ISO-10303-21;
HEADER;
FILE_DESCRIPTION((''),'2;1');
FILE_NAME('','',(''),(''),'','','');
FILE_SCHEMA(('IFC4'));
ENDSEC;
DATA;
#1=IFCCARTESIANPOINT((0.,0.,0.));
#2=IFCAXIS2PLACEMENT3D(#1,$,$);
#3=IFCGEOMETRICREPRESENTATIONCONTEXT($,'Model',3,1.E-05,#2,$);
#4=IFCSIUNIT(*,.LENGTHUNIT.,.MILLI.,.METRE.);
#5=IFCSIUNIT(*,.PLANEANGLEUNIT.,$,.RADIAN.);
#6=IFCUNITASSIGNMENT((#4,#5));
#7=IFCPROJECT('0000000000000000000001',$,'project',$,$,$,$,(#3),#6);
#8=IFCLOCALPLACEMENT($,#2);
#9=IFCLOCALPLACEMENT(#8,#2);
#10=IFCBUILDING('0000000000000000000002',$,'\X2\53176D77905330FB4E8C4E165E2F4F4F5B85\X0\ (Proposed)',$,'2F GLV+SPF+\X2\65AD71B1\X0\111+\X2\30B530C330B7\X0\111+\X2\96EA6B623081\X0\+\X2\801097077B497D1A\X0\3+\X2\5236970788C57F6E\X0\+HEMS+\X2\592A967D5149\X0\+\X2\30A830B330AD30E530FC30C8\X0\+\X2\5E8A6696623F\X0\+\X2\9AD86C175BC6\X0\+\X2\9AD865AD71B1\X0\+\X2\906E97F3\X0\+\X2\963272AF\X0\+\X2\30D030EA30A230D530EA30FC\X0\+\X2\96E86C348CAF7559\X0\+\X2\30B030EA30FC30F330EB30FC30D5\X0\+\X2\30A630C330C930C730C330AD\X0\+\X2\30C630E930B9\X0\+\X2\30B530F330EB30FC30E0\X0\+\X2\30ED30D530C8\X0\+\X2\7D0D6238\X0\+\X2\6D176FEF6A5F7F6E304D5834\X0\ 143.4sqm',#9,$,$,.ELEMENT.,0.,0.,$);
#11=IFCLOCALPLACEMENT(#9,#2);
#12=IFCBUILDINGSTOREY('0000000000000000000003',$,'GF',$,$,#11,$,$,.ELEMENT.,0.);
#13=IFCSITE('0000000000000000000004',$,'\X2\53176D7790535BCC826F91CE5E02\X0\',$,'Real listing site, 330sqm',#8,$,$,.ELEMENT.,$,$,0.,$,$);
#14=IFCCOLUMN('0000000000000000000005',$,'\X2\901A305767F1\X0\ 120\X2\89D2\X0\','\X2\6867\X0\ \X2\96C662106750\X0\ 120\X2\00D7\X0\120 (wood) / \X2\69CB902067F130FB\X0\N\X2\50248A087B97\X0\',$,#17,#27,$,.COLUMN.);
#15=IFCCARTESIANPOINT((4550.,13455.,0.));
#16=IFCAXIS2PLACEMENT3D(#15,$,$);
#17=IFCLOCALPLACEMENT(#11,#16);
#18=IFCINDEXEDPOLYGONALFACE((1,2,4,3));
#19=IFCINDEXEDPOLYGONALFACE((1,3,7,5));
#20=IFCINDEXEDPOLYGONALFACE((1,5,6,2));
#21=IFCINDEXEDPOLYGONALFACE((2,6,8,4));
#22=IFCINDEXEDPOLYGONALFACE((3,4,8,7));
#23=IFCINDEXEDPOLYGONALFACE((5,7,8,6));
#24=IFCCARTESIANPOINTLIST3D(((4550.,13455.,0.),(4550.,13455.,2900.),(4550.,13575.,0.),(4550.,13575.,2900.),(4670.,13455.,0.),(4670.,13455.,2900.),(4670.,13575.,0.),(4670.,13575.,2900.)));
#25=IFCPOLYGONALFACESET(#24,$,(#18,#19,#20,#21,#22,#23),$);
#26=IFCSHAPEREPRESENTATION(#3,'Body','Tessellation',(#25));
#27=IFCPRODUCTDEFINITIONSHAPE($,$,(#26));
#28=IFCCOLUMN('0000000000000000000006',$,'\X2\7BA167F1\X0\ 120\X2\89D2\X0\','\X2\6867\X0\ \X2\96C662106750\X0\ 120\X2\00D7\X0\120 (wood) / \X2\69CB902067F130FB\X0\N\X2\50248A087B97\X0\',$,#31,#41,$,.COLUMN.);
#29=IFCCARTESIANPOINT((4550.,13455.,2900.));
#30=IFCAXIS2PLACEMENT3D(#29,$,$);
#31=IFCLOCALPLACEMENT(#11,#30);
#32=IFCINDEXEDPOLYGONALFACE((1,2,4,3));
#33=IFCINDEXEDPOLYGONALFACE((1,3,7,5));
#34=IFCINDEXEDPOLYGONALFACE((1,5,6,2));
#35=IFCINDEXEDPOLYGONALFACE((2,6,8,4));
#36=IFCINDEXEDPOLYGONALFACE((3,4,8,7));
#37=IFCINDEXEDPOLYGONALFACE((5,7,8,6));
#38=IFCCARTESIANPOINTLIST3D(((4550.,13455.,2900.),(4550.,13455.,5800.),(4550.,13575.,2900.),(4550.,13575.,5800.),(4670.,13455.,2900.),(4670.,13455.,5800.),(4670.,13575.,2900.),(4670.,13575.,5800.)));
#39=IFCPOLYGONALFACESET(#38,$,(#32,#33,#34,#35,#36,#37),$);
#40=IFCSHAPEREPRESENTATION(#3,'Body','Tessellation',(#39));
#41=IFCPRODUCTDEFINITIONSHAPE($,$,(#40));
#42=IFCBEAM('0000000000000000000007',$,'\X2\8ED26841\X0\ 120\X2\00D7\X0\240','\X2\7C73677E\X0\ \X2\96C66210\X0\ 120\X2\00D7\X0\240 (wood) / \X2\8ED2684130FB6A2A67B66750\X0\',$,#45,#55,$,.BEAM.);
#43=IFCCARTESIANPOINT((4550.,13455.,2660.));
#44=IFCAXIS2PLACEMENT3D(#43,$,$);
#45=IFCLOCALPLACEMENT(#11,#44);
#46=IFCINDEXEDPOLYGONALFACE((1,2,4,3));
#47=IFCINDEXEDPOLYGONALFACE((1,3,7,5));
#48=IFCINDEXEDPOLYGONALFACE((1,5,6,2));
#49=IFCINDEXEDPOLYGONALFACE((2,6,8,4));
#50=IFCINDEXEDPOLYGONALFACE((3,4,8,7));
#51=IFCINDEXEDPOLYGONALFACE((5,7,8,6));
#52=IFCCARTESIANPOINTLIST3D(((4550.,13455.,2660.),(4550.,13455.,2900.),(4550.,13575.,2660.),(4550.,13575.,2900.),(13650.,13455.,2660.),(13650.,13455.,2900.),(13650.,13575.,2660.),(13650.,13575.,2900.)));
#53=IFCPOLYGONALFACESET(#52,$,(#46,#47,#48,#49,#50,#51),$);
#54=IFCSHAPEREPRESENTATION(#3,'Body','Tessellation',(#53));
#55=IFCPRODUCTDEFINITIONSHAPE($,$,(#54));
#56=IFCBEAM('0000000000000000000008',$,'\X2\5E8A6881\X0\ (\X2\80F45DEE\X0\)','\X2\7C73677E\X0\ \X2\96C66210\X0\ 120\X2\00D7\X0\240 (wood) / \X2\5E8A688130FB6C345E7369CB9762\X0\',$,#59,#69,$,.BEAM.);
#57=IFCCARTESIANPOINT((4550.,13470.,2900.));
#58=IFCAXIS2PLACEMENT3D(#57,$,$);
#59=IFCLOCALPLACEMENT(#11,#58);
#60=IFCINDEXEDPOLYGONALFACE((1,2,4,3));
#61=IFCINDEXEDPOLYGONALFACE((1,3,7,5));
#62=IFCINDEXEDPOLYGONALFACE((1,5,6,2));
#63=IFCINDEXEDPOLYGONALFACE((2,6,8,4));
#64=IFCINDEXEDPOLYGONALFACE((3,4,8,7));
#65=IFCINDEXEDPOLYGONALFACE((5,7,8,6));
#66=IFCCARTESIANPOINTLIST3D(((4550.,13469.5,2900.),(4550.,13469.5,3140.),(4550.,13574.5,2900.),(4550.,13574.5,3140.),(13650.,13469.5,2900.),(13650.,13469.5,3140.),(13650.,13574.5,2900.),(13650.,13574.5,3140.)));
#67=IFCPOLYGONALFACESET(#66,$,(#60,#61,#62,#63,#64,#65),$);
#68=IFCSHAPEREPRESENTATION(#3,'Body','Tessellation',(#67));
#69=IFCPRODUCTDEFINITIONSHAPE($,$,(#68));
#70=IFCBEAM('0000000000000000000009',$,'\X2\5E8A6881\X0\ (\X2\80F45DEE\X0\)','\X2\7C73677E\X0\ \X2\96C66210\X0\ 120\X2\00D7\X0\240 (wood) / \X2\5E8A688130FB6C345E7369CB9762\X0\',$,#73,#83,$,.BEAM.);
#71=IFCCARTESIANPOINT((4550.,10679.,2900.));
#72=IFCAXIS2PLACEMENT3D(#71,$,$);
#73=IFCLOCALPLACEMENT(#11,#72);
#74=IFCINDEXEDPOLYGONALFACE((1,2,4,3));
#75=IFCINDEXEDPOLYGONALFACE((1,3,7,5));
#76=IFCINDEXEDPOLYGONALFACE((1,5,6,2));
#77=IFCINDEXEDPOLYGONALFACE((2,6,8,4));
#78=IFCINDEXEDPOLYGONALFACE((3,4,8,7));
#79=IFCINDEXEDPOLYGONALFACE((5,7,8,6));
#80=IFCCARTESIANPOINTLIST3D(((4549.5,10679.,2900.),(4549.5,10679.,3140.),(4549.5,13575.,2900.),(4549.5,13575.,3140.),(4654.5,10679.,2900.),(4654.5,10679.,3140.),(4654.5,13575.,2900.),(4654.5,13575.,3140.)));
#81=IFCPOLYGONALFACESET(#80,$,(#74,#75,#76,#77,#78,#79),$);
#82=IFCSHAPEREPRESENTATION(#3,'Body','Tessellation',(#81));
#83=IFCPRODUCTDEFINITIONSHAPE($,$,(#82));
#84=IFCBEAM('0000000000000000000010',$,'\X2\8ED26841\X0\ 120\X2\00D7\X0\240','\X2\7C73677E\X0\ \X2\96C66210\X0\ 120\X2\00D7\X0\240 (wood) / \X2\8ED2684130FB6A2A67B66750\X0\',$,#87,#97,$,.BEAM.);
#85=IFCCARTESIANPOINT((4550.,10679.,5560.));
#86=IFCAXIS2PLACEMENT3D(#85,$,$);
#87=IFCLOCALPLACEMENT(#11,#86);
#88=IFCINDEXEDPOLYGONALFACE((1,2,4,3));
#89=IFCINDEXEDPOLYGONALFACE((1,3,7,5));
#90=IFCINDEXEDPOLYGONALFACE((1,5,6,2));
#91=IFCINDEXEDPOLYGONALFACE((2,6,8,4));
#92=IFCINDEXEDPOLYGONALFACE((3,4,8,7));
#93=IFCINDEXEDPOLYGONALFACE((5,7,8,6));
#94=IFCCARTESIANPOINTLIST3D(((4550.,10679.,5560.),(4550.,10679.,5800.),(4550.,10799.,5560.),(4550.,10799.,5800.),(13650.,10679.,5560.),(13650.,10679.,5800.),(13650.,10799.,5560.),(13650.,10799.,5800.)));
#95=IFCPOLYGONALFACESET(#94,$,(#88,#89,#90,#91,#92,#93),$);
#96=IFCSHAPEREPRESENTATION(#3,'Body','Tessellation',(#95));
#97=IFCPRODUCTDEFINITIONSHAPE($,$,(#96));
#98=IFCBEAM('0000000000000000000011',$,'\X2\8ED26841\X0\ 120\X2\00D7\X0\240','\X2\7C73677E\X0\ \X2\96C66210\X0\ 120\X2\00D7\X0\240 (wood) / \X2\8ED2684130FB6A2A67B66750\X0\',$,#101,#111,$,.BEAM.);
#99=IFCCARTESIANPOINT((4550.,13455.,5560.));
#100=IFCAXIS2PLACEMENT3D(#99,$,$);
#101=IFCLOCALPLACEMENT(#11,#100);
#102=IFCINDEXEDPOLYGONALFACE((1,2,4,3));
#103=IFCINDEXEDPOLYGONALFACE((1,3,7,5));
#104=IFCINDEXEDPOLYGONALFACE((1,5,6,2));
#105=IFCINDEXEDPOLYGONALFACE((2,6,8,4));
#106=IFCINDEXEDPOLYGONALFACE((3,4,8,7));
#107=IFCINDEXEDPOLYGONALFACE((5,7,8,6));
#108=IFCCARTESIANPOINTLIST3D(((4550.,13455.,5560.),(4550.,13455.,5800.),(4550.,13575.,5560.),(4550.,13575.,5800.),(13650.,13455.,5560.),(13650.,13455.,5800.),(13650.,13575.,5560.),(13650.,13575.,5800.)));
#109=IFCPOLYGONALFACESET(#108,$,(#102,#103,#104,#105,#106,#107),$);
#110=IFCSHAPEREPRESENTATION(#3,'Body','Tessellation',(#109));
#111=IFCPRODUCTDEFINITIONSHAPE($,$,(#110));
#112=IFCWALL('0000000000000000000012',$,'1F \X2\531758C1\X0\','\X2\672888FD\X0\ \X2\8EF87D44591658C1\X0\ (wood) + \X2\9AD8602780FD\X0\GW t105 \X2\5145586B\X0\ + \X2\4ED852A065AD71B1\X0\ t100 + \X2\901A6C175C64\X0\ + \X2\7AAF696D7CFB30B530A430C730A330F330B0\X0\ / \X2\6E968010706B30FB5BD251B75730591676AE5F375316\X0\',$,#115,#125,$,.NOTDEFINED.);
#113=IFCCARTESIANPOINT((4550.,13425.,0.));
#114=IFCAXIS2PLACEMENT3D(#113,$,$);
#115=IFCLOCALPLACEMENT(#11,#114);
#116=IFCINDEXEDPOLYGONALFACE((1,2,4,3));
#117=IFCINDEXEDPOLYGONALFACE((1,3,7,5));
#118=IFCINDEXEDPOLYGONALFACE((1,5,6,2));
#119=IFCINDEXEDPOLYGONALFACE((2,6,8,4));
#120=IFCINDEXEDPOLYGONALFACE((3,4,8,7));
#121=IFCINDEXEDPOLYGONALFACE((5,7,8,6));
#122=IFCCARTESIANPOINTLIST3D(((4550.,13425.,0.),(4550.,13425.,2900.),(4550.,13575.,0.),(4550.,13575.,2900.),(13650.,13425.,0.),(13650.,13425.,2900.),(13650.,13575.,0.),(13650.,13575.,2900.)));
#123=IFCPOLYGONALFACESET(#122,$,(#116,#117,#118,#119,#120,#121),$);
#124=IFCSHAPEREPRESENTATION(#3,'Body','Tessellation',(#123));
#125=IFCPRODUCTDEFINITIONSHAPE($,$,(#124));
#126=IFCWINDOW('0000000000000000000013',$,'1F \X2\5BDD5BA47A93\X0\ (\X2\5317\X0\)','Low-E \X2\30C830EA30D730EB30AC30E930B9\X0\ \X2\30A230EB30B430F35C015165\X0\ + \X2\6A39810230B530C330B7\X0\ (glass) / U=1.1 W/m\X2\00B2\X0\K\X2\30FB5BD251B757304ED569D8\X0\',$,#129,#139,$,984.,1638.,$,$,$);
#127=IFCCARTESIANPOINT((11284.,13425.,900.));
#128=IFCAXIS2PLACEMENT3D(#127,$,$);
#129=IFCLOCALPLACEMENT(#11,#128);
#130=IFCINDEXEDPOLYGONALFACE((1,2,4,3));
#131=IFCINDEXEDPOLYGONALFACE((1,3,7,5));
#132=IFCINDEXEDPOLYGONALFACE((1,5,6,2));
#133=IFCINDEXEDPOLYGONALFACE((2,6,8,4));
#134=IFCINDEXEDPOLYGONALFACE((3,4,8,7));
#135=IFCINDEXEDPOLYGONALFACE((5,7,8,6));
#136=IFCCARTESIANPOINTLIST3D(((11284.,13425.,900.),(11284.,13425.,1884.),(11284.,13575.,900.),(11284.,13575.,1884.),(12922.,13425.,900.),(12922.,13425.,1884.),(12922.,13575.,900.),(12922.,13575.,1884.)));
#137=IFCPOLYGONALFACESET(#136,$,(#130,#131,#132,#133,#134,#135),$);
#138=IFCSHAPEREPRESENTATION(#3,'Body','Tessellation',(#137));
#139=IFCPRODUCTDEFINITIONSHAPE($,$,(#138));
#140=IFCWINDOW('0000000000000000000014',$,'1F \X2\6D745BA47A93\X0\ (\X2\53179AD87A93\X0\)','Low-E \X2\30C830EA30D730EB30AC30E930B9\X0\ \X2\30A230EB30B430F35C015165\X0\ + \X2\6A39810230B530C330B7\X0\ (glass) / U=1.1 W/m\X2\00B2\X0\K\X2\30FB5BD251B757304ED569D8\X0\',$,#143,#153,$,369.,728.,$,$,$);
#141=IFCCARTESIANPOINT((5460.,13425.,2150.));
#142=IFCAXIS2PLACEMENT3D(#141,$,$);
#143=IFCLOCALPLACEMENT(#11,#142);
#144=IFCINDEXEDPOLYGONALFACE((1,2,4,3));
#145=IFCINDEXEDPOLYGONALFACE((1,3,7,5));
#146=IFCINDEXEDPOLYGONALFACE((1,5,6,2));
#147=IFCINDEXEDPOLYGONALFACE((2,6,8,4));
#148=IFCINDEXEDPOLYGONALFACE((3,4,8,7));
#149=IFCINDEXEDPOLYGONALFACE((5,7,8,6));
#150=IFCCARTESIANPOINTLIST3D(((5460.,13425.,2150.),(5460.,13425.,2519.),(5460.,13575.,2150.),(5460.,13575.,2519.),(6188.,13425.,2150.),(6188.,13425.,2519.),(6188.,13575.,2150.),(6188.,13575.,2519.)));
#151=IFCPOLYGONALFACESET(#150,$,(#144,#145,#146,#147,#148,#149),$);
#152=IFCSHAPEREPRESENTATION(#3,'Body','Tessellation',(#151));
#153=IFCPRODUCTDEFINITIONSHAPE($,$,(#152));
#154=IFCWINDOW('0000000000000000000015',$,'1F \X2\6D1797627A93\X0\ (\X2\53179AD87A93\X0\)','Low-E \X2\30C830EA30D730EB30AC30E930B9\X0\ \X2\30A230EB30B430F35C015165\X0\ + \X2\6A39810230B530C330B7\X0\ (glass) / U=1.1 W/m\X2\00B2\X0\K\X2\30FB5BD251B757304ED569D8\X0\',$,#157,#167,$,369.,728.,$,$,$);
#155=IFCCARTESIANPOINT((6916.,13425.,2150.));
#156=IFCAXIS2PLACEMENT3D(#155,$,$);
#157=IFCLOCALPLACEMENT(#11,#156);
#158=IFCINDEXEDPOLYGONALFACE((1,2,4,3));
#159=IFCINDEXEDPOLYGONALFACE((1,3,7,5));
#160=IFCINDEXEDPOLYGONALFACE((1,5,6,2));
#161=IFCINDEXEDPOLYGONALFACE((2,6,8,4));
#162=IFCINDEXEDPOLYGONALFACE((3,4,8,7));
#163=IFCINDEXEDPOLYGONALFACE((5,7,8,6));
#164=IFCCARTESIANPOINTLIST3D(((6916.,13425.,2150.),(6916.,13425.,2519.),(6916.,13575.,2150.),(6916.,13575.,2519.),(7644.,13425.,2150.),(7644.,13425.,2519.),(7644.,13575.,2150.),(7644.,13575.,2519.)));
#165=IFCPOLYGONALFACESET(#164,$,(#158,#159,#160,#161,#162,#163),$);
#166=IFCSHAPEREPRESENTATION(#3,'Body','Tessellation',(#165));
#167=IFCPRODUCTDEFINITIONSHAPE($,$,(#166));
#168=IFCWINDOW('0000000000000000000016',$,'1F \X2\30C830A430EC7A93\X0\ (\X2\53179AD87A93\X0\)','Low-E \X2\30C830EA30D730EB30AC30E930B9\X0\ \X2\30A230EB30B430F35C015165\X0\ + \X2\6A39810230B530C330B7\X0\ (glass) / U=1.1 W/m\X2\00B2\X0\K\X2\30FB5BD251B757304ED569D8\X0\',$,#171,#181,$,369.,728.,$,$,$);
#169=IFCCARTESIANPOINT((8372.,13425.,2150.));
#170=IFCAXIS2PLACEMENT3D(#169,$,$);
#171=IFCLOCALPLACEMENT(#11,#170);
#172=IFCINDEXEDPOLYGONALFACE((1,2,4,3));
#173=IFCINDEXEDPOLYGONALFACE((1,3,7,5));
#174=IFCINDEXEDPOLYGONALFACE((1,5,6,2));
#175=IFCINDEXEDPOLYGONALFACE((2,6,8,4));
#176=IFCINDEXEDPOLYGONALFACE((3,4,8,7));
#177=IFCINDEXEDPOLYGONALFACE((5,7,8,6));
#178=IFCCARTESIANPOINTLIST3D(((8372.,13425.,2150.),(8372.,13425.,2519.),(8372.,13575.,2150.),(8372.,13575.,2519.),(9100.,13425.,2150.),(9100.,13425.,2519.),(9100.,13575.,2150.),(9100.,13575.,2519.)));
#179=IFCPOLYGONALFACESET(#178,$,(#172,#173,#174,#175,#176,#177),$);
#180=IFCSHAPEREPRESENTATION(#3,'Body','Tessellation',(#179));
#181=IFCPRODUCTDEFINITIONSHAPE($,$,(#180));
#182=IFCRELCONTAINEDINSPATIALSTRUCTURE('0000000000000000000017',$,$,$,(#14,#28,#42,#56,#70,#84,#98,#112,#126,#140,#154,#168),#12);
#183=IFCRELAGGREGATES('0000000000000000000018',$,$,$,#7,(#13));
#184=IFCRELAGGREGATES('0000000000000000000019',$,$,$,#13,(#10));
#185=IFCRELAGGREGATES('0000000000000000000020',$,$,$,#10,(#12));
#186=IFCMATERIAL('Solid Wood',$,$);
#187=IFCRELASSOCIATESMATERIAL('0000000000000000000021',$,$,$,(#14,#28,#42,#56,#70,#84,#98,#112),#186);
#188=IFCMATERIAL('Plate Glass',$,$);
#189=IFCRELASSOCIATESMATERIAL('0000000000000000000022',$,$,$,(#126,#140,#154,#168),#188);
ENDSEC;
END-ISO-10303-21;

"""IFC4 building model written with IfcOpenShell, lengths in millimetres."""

from ifc_helpers import new_model, si_unit, frame, frame_2d, origin, place, context, project, spatial, rectangle, extrude, material, element, fill, save


model = new_model("IFC4")

# Units and contexts
model_context = context("Model", 3, precision=1e-05, world=origin())
ifc_project = project(units=[si_unit("LENGTHUNIT", "METRE", prefix="MILLI"), si_unit("PLANEANGLEUNIT", "RADIAN")], contexts=[model_context])

# Site, building, storey
site_placement = place(None, origin())
site = spatial("IfcSite", under=ifc_project, at=site_placement, Name="北海道富良野市", ObjectType="Real listing site, 330sqm", CompositionType="ELEMENT", RefElevation=0.0)
building_placement = place(site_placement, origin())
building = spatial("IfcBuilding", under=site, at=building_placement, Name="北海道・二世帯住宅 (Proposed)", ObjectType="2F GLV+SPF+断熱111+サッシ111+雪止め+耐震等級3+制震装置+HEMS+太陽光+エコキュート+床暖房+高気密+高断熱+遮音+防犯+バリアフリー+雨水貯留+グリーンルーフ+ウッドデッキ+テラス+サンルーム+ロフト+納戸+洗濯機置き場 143.4sqm", CompositionType="ELEMENT", ElevationOfRefHeight=0.0, ElevationOfTerrain=0.0)
storey_placement = place(building_placement, origin())
storey = spatial("IfcBuildingStorey", under=building, at=storey_placement, Name="GF", CompositionType="ELEMENT", Elevation=0.0)

# Columns
ifc_material_1 = material(Name="Solid Wood")
column_1_placement = place(storey_placement, frame((4550.0, 13455.0, 0.0)))
element("IfcColumn", 1, at=column_1_placement, inside=storey, material=ifc_material_1, Name="通し柱 120角", Description="桧 集成材 120×120 (wood) / 構造柱・N値計算", PredefinedType="COLUMN", context=model_context, shape_type="SweptSolid", body=[
    extrude(rectangle(XDim=120.0, YDim=120.0, at=frame_2d((60.0, 60.0))), frame((4550.0, 13455.0, 0.0)), (0.0, 0.0, 1.0), 2900.0),
])
column_2_placement = place(storey_placement, frame((4550.0, 13455.0, 2900.0)))
element("IfcColumn", 2, at=column_2_placement, inside=storey, material=ifc_material_1, Name="管柱 120角", Description="桧 集成材 120×120 (wood) / 構造柱・N値計算", PredefinedType="COLUMN", context=model_context, shape_type="SweptSolid", body=[
    extrude(rectangle(XDim=120.0, YDim=120.0, at=frame_2d((60.0, 60.0))), frame((4550.0, 13455.0, 2900.0)), (0.0, 0.0, 1.0), 2900.0),
])

# Beams
beam_1_placement = place(storey_placement, frame((4550.0, 13455.0, 2660.0)))
element("IfcBeam", 3, at=beam_1_placement, inside=storey, material=ifc_material_1, Name="軒桁 120×240", Description="米松 集成 120×240 (wood) / 軒桁・横架材", PredefinedType="BEAM", context=model_context, shape_type="SweptSolid", body=[
    extrude(rectangle(XDim=9100.0, YDim=120.0, at=frame_2d((4550.0, 60.0))), frame((4550.0, 13455.0, 2660.0)), (0.0, 0.0, 1.0), 240.0),
])
beam_2_placement = place(storey_placement, frame((4550.0, 13470.0, 2900.0)))
element("IfcBeam", 4, at=beam_2_placement, inside=storey, material=ifc_material_1, Name="床梁 (胴差)", Description="米松 集成 120×240 (wood) / 床梁・水平構面", PredefinedType="BEAM", context=model_context, shape_type="SweptSolid", body=[
    extrude(rectangle(XDim=9100.0, YDim=105.0, at=frame_2d((4550.0, 52.0))), frame((4550.0, 13470.0, 2900.0)), (0.0, 0.0, 1.0), 240.0),
])
beam_3_placement = place(storey_placement, frame((4550.0, 10679.0, 2900.0)))
element("IfcBeam", 5, at=beam_3_placement, inside=storey, material=ifc_material_1, Name="床梁 (胴差)", Description="米松 集成 120×240 (wood) / 床梁・水平構面", PredefinedType="BEAM", context=model_context, shape_type="SweptSolid", body=[
    extrude(rectangle(XDim=105.0, YDim=2896.0, at=frame_2d((52.0, 1448.0))), frame((4550.0, 10679.0, 2900.0)), (0.0, 0.0, 1.0), 240.0),
])
beam_4_placement = place(storey_placement, frame((4550.0, 10679.0, 5560.0)))
element("IfcBeam", 6, at=beam_4_placement, inside=storey, material=ifc_material_1, Name="軒桁 120×240", Description="米松 集成 120×240 (wood) / 軒桁・横架材", PredefinedType="BEAM", context=model_context, shape_type="SweptSolid", body=[
    extrude(rectangle(XDim=9100.0, YDim=120.0, at=frame_2d((4550.0, 60.0))), frame((4550.0, 10679.0, 5560.0)), (0.0, 0.0, 1.0), 240.0),
])
beam_5_placement = place(storey_placement, frame((4550.0, 13455.0, 5560.0)))
element("IfcBeam", 7, at=beam_5_placement, inside=storey, material=ifc_material_1, Name="軒桁 120×240", Description="米松 集成 120×240 (wood) / 軒桁・横架材", PredefinedType="BEAM", context=model_context, shape_type="SweptSolid", body=[
    extrude(rectangle(XDim=9100.0, YDim=120.0, at=frame_2d((4550.0, 60.0))), frame((4550.0, 13455.0, 5560.0)), (0.0, 0.0, 1.0), 240.0),
])

# Wall, openings, windows
wall_1_placement = place(storey_placement, frame((4550.0, 13425.0, 0.0)))
wall_1 = element("IfcWall", 8, at=wall_1_placement, inside=storey, material=ifc_material_1, Name="1F 北壁", Description="木製 軸組外壁 (wood) + 高性能GW t105 充填 + 付加断熱 t100 + 通気層 + 窯業系サイディング / 準耐火・寒冷地外皮強化", PredefinedType="NOTDEFINED", context=model_context, shape_type="SweptSolid", body=[
    extrude(rectangle(XDim=9100.0, YDim=150.0, at=frame_2d((4550.0, 75.0))), frame((4550.0, 13425.0, 0.0)), (0.0, 0.0, 1.0), 2900.0),
])
opening_1_placement = place(storey_placement, frame((11284.0, 13425.0, 900.0)))
opening_1 = element("IfcOpeningElement", 9, at=opening_1_placement, cuts=wall_1, PredefinedType="NOTDEFINED", context=model_context, shape_type="SweptSolid", body=[
    extrude(rectangle(XDim=1638.0, YDim=150.0, at=frame_2d((819.0, 75.0))), frame((11284.0, 13425.0, 900.0)), (0.0, 0.0, 1.0), 984.0),
])
opening_2_placement = place(storey_placement, frame((5460.0, 13425.0, 2150.0)))
opening_2 = element("IfcOpeningElement", 10, at=opening_2_placement, cuts=wall_1, PredefinedType="NOTDEFINED", context=model_context, shape_type="SweptSolid", body=[
    extrude(rectangle(XDim=728.0, YDim=150.0, at=frame_2d((364.0, 75.0))), frame((5460.0, 13425.0, 2150.0)), (0.0, 0.0, 1.0), 369.0),
])
opening_3_placement = place(storey_placement, frame((6916.0, 13425.0, 2150.0)))
opening_3 = element("IfcOpeningElement", 11, at=opening_3_placement, cuts=wall_1, PredefinedType="NOTDEFINED", context=model_context, shape_type="SweptSolid", body=[
    extrude(rectangle(XDim=728.0, YDim=150.0, at=frame_2d((364.0, 75.0))), frame((6916.0, 13425.0, 2150.0)), (0.0, 0.0, 1.0), 369.0),
])
opening_4_placement = place(storey_placement, frame((8372.0, 13425.0, 2150.0)))
opening_4 = element("IfcOpeningElement", 12, at=opening_4_placement, cuts=wall_1, PredefinedType="NOTDEFINED", context=model_context, shape_type="SweptSolid", body=[
    extrude(rectangle(XDim=728.0, YDim=150.0, at=frame_2d((364.0, 75.0))), frame((8372.0, 13425.0, 2150.0)), (0.0, 0.0, 1.0), 369.0),
])
ifc_material_2 = material(Name="Plate Glass")
window_1_placement = place(storey_placement, frame((11284.0, 13425.0, 900.0)))
window_1 = element("IfcWindow", 13, at=window_1_placement, inside=storey, material=ifc_material_2, Name="1F 寝室窓 (北)", Description="Low-E トリプルガラス アルゴン封入 + 樹脂サッシ (glass) / U=1.1 W/m²K・寒冷地仕様", OverallHeight=984.0, OverallWidth=1638.0, context=model_context, shape_type="SweptSolid", body=[
    extrude(rectangle(XDim=1638.0, YDim=150.0, at=frame_2d((819.0, 75.0))), frame((11284.0, 13425.0, 900.0)), (0.0, 0.0, 1.0), 984.0),
])
fill(opening_1, window_1)
window_2_placement = place(storey_placement, frame((5460.0, 13425.0, 2150.0)))
window_2 = element("IfcWindow", 14, at=window_2_placement, inside=storey, material=ifc_material_2, Name="1F 浴室窓 (北高窓)", Description="Low-E トリプルガラス アルゴン封入 + 樹脂サッシ (glass) / U=1.1 W/m²K・寒冷地仕様", OverallHeight=369.0, OverallWidth=728.0, context=model_context, shape_type="SweptSolid", body=[
    extrude(rectangle(XDim=728.0, YDim=150.0, at=frame_2d((364.0, 75.0))), frame((5460.0, 13425.0, 2150.0)), (0.0, 0.0, 1.0), 369.0),
])
fill(opening_2, window_2)
window_3_placement = place(storey_placement, frame((6916.0, 13425.0, 2150.0)))
window_3 = element("IfcWindow", 15, at=window_3_placement, inside=storey, material=ifc_material_2, Name="1F 洗面窓 (北高窓)", Description="Low-E トリプルガラス アルゴン封入 + 樹脂サッシ (glass) / U=1.1 W/m²K・寒冷地仕様", OverallHeight=369.0, OverallWidth=728.0, context=model_context, shape_type="SweptSolid", body=[
    extrude(rectangle(XDim=728.0, YDim=150.0, at=frame_2d((364.0, 75.0))), frame((6916.0, 13425.0, 2150.0)), (0.0, 0.0, 1.0), 369.0),
])
fill(opening_3, window_3)
window_4_placement = place(storey_placement, frame((8372.0, 13425.0, 2150.0)))
window_4 = element("IfcWindow", 16, at=window_4_placement, inside=storey, material=ifc_material_2, Name="1F トイレ窓 (北高窓)", Description="Low-E トリプルガラス アルゴン封入 + 樹脂サッシ (glass) / U=1.1 W/m²K・寒冷地仕様", OverallHeight=369.0, OverallWidth=728.0, context=model_context, shape_type="SweptSolid", body=[
    extrude(rectangle(XDim=728.0, YDim=150.0, at=frame_2d((364.0, 75.0))), frame((8372.0, 13425.0, 2150.0)), (0.0, 0.0, 1.0), 369.0),
])
fill(opening_4, window_4)

save(model, "model.ifc")
